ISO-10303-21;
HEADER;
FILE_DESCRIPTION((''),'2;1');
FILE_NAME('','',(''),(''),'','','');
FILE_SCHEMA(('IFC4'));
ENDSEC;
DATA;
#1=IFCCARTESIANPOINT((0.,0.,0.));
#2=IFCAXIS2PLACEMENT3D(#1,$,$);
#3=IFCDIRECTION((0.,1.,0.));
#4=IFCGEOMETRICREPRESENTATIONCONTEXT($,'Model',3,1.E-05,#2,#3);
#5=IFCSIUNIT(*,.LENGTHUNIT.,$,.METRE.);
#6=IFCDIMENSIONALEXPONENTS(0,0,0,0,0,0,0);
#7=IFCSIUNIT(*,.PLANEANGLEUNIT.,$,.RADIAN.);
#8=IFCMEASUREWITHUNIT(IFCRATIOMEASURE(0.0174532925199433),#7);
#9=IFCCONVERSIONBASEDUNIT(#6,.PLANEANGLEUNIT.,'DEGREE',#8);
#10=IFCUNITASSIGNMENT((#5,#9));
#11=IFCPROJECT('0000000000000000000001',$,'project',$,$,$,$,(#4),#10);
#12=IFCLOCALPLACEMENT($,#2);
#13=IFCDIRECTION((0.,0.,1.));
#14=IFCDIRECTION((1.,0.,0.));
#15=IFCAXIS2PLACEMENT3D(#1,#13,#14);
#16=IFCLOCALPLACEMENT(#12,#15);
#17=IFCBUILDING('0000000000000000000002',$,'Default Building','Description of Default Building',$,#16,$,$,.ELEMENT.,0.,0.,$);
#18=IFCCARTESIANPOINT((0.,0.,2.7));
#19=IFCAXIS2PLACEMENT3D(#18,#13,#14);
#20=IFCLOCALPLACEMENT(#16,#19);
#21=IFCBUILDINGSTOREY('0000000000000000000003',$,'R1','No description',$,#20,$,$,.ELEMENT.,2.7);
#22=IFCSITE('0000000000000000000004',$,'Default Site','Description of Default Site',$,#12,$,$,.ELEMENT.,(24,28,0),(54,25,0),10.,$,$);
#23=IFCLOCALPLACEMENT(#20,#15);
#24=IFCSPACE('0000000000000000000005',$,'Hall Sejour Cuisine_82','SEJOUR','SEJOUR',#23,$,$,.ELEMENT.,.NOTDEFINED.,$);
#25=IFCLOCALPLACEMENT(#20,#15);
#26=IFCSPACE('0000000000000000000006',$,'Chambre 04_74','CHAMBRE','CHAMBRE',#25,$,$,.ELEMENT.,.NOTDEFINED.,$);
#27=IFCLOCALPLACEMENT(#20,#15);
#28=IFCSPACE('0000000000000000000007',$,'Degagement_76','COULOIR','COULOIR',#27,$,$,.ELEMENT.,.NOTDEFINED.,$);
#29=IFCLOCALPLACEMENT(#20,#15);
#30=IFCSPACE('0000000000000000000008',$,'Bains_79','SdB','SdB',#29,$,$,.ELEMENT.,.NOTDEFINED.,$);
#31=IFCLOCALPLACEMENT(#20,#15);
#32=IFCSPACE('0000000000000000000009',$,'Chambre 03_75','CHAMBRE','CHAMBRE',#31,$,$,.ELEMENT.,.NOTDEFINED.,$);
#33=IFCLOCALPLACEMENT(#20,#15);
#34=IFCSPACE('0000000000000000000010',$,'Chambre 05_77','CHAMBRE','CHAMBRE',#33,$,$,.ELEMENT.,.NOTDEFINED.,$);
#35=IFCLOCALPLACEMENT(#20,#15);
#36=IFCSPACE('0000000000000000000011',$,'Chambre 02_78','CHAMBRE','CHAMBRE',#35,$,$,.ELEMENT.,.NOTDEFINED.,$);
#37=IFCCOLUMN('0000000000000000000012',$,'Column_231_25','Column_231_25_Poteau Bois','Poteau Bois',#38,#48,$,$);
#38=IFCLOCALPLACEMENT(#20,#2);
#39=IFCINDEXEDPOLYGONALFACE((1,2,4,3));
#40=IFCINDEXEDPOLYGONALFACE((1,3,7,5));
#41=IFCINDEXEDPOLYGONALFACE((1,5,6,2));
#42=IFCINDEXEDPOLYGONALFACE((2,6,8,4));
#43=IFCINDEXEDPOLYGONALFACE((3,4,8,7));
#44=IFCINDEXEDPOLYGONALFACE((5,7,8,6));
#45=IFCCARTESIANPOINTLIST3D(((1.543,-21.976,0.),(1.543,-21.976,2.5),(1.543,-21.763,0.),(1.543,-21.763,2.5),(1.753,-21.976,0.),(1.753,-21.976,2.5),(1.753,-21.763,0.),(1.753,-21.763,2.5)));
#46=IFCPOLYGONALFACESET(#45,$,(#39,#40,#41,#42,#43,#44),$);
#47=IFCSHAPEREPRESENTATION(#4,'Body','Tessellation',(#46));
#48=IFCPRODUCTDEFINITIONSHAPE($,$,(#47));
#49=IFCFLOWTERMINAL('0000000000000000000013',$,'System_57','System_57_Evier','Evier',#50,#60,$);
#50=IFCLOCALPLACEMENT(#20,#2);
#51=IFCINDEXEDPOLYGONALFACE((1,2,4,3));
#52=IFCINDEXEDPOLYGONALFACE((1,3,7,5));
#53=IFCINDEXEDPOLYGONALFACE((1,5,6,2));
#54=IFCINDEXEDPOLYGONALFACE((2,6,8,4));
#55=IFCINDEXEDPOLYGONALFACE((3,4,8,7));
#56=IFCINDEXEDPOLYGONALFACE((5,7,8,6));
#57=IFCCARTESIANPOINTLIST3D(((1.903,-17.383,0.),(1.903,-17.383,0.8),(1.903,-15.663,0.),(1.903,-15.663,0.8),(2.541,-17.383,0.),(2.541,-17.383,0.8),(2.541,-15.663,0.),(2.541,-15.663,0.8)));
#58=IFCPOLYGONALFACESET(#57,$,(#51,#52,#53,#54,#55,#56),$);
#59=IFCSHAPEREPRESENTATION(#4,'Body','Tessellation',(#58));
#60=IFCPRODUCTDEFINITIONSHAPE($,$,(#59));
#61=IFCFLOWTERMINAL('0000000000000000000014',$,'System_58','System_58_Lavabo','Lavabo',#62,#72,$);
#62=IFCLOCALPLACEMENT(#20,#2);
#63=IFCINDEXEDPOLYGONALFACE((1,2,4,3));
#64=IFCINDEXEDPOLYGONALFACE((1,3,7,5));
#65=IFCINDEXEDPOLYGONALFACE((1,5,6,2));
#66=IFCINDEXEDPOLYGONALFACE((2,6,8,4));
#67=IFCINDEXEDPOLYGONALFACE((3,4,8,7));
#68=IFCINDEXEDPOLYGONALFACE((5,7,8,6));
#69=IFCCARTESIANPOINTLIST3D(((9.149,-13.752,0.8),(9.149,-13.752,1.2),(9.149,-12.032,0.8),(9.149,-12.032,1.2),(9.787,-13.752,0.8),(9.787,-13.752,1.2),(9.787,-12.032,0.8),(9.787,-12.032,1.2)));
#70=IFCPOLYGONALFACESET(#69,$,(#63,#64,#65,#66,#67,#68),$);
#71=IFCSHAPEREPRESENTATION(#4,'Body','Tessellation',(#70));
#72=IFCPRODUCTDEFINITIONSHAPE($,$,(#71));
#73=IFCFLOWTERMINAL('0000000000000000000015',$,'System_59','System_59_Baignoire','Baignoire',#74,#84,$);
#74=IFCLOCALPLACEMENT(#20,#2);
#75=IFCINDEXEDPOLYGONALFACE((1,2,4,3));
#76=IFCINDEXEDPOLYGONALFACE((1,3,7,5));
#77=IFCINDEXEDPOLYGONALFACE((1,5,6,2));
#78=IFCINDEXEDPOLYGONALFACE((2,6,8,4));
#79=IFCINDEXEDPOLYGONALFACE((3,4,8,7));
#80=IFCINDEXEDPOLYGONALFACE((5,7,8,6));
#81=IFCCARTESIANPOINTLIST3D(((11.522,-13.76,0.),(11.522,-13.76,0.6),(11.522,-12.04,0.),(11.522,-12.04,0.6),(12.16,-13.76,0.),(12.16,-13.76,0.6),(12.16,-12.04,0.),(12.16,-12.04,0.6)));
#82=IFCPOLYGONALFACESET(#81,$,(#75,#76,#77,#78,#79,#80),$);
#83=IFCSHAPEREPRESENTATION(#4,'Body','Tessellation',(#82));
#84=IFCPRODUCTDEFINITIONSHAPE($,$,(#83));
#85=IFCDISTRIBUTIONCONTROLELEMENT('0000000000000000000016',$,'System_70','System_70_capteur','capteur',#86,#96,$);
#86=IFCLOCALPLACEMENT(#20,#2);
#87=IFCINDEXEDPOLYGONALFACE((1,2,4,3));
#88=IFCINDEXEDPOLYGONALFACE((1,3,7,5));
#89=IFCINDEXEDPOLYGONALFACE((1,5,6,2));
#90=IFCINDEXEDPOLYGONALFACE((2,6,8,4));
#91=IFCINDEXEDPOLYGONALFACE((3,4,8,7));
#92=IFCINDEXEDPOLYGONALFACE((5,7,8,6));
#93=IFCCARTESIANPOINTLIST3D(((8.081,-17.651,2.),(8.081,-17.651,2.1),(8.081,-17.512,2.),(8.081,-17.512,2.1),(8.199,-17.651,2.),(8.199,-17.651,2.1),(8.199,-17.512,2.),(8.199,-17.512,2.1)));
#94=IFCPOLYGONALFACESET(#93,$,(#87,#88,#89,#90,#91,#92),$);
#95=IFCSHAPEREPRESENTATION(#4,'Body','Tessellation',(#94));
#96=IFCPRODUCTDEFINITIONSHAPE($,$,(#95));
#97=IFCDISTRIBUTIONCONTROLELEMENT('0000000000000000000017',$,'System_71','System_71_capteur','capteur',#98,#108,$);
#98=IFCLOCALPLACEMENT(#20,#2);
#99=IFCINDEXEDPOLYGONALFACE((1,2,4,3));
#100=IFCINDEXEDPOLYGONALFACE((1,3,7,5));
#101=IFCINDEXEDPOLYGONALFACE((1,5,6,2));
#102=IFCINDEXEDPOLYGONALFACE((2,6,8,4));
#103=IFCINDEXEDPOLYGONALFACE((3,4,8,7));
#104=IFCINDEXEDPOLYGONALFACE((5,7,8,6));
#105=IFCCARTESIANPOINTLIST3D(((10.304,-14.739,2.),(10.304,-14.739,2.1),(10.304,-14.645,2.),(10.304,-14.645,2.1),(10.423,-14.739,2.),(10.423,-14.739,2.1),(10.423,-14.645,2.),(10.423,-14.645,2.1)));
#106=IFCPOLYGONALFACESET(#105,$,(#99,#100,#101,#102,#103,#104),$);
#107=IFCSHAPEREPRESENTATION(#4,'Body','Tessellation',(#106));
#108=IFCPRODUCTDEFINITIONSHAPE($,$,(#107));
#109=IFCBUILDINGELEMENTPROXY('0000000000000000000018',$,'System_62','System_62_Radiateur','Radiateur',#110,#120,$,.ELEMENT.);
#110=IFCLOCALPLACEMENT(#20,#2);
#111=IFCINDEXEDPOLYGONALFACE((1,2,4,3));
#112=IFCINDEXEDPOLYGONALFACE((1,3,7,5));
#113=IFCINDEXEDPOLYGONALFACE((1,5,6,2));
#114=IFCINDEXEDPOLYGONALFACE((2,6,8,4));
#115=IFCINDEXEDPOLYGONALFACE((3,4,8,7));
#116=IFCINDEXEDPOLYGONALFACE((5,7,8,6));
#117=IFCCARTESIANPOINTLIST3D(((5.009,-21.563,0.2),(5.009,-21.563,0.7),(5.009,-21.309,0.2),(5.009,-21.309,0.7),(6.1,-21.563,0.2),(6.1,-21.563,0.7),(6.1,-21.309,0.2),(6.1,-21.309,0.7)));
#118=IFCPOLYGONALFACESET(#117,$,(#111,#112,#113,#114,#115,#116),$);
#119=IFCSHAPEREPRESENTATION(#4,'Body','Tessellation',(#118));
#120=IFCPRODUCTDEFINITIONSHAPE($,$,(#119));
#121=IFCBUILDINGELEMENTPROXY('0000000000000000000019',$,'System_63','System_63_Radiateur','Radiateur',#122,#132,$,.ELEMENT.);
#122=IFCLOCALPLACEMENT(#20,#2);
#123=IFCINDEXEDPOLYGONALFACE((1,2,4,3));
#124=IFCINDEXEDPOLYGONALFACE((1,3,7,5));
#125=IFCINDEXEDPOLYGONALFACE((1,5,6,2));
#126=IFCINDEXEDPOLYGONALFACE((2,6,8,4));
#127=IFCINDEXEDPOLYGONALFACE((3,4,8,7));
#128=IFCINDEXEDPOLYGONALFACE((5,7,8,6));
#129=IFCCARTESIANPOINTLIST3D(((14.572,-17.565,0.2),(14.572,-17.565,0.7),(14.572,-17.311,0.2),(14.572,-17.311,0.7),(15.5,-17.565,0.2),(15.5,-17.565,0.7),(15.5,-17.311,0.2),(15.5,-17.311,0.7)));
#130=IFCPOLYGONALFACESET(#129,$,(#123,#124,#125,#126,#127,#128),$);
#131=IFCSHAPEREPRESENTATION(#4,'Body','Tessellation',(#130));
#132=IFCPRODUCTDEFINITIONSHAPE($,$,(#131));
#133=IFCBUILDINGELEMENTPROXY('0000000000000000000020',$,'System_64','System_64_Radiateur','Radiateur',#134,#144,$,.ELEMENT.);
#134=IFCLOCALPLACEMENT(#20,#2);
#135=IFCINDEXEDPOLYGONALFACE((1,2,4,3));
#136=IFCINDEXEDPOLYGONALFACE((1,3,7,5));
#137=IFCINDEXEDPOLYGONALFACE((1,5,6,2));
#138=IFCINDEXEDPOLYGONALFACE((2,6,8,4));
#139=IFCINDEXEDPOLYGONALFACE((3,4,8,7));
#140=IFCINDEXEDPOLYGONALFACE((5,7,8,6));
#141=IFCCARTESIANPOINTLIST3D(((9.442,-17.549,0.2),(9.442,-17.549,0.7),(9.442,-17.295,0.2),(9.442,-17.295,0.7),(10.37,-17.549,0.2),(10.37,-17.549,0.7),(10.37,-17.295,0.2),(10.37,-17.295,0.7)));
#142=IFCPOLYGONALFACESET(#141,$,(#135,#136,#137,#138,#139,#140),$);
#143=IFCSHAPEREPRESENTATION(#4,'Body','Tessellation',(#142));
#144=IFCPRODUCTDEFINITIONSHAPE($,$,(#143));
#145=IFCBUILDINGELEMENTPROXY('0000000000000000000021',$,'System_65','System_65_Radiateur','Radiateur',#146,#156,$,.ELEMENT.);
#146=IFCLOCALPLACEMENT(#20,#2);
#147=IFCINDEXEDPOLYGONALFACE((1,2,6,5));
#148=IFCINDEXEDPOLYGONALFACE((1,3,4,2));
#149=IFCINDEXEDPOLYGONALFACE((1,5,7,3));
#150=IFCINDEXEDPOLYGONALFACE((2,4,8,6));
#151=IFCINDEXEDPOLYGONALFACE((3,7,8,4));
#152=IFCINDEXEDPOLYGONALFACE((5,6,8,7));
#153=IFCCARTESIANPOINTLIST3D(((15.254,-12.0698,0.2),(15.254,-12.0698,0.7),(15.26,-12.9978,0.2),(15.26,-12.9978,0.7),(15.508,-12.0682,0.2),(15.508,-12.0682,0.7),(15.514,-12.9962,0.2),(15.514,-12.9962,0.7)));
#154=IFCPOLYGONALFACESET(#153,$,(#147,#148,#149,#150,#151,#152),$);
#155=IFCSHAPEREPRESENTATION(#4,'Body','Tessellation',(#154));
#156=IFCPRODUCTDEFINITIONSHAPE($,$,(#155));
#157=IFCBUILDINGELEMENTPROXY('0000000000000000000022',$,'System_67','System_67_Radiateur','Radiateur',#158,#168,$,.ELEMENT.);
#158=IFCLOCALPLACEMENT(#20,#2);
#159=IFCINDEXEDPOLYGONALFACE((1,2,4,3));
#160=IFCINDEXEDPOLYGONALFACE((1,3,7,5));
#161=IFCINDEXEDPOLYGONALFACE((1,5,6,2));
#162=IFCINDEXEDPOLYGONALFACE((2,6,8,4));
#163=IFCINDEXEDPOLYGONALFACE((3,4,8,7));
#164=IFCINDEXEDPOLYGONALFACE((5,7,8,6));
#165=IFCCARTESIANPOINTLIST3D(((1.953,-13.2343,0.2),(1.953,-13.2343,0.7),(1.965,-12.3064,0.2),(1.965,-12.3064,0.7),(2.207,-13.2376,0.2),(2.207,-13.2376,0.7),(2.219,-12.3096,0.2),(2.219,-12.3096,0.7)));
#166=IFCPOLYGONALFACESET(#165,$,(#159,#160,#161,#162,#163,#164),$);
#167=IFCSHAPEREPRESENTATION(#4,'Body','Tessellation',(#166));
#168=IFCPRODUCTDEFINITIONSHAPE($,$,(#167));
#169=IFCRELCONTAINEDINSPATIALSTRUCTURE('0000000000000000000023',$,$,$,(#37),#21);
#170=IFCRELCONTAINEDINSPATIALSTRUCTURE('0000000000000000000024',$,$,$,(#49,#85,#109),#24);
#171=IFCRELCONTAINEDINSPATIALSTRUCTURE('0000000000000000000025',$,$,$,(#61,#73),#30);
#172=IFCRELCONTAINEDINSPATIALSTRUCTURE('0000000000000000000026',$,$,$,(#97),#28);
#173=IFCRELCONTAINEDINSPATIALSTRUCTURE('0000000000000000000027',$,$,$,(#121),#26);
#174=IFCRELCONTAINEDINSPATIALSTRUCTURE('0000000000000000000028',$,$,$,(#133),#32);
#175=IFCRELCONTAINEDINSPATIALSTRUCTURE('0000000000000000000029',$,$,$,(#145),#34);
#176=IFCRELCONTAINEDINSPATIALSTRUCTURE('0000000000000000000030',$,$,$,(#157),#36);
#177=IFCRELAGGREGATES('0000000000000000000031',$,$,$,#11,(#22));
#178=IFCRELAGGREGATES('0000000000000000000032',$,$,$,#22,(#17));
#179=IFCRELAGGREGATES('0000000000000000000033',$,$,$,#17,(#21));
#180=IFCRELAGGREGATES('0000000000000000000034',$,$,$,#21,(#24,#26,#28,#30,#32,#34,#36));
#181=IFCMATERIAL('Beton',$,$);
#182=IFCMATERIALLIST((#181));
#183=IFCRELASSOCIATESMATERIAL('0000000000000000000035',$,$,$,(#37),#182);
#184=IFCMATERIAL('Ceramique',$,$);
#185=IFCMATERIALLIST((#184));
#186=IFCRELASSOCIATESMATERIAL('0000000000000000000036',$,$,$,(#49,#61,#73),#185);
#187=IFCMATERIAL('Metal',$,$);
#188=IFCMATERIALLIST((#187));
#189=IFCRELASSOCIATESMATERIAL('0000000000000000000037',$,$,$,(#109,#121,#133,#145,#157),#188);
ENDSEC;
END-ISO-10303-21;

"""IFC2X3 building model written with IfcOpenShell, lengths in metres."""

from ifc_helpers import new_model, entity, si_unit, converted_unit, direction, frame, origin, origin_with_axes, place, context, project, spatial, polyline, outline, extrude, material, material_list, element, save


model = new_model("IFC2X3")

# Units and contexts
model_context = context("Model", 3, precision=1e-05, world=origin(), true_north=direction((0.0, 1.0, 0.0)))
ifc_project = project(units=[si_unit("LENGTHUNIT", "METRE"), converted_unit("PLANEANGLEUNIT", "DEGREE", entity("IfcRatioMeasure", 0.0174532925199433), si_unit("PLANEANGLEUNIT", "RADIAN"), dimensions=[0, 0, 0, 0, 0, 0, 0])], contexts=[model_context])

# Site, building, storey
site_placement = place(None, origin())
site = spatial("IfcSite", under=ifc_project, at=site_placement, Name="Default Site", Description="Description of Default Site", CompositionType="ELEMENT", RefLatitude=(24, 28, 0), RefLongitude=(54, 25, 0), RefElevation=10.0)
building_placement = place(site_placement, origin_with_axes())
building = spatial("IfcBuilding", under=site, at=building_placement, Name="Default Building", Description="Description of Default Building", CompositionType="ELEMENT", ElevationOfRefHeight=0.0, ElevationOfTerrain=0.0)
storey_placement = place(building_placement, frame((0.0, 0.0, 2.7), z_axis=(0.0, 0.0, 1.0), x_axis=(1.0, 0.0, 0.0)))
storey = spatial("IfcBuildingStorey", under=building, at=storey_placement, Name="R1", Description="No description", CompositionType="ELEMENT", Elevation=2.7)

# Column
ifc_material_1 = material(Name="Beton")
ifc_material_list_1 = material_list([ifc_material_1])
column_placement = place(storey_placement, frame((1.648, -21.763, 0.0), z_axis=(0.0, 0.0, 1.0), x_axis=(0.0, -0.213, 0.0)))
element("IfcColumn", 1, at=column_placement, inside=storey, material=ifc_material_list_1, Name="Column_231_25", Description="Column_231_25_Poteau Bois", ObjectType="Poteau Bois", context=model_context, shape_type="SweptSolid", body=[
    extrude(outline(polyline([(0.0, -0.105), (0.213, -0.105), (0.213, 0.105), (0.0, 0.105), (0.0, -0.105)])), origin(), (0.0, 0.0, 1.0), 2.5),
])

# Shared definitions
space_1_placement = place(storey_placement, origin_with_axes())
space_1 = spatial("IfcSpace", under=storey, at=space_1_placement, Name="Hall Sejour Cuisine_82", Description="SEJOUR", ObjectType="SEJOUR", CompositionType="ELEMENT", InteriorOrExteriorSpace="NOTDEFINED")

# Shared definitions
space_2_placement = place(storey_placement, origin_with_axes())
space_2 = spatial("IfcSpace", under=storey, at=space_2_placement, Name="Chambre 04_74", Description="CHAMBRE", ObjectType="CHAMBRE", CompositionType="ELEMENT", InteriorOrExteriorSpace="NOTDEFINED")

# Shared definitions
space_3_placement = place(storey_placement, origin_with_axes())
space_3 = spatial("IfcSpace", under=storey, at=space_3_placement, Name="Degagement_76", Description="COULOIR", ObjectType="COULOIR", CompositionType="ELEMENT", InteriorOrExteriorSpace="NOTDEFINED")

# Shared definitions
ifc_material_2 = material(Name="Metal")
ifc_material_list_2 = material_list([ifc_material_2])

# Flow terminal
ifc_material_3 = material(Name="Ceramique")
ifc_material_list_3 = material_list([ifc_material_3])
flow_terminal_1_placement = place(storey_placement, frame((2.222, -15.663, 0.0), z_axis=(0.0, 0.0, 1.0), x_axis=(0.0, -1.72, 0.0)))
element("IfcFlowTerminal", 2, at=flow_terminal_1_placement, inside=space_1, material=ifc_material_list_3, Name="System_57", Description="System_57_Evier", ObjectType="Evier", context=model_context, shape_type="SweptSolid", body=[
    extrude(outline(polyline([(0.0, -0.319), (1.72, -0.319), (1.72, 0.319), (0.0, 0.319), (0.0, -0.319)])), origin(), (0.0, 0.0, 1.0), 0.8),
])

# Shared definitions
space_4_placement = place(storey_placement, origin_with_axes())
space_4 = spatial("IfcSpace", under=storey, at=space_4_placement, Name="Bains_79", Description="SdB", ObjectType="SdB", CompositionType="ELEMENT", InteriorOrExteriorSpace="NOTDEFINED")

# Flow terminals
flow_terminal_2_placement = place(storey_placement, frame((9.468, -12.032, 0.8), z_axis=(0.0, 0.0, 1.0), x_axis=(0.0, -1.72, 0.0)))
element("IfcFlowTerminal", 3, at=flow_terminal_2_placement, inside=space_4, material=ifc_material_list_3, Name="System_58", Description="System_58_Lavabo", ObjectType="Lavabo", context=model_context, shape_type="SweptSolid", body=[
    extrude(outline(polyline([(0.0, -0.319), (1.72, -0.319), (1.72, 0.319), (0.0, 0.319), (0.0, -0.319)])), origin(), (0.0, 0.0, 1.0), 0.4),
])
flow_terminal_3_placement = place(storey_placement, frame((11.841, -12.04, 0.0), z_axis=(0.0, 0.0, 1.0), x_axis=(0.0, -1.72, 0.0)))
element("IfcFlowTerminal", 4, at=flow_terminal_3_placement, inside=space_4, material=ifc_material_list_3, Name="System_59", Description="System_59_Baignoire", ObjectType="Baignoire", context=model_context, shape_type="SweptSolid", body=[
    extrude(outline(polyline([(0.0, -0.319), (1.72, -0.319), (1.72, 0.319), (0.0, 0.319), (0.0, -0.319)])), origin(), (0.0, 0.0, 1.0), 0.6),
])

# Distribution control elements
distribution_control_element_1_placement = place(storey_placement, frame((8.14, -17.512, 2.0), z_axis=(0.0, 0.0, 1.0), x_axis=(0.0, -0.139, 0.0)))
element("IfcDistributionControlElement", 5, at=distribution_control_element_1_placement, inside=space_1, Name="System_70", Description="System_70_capteur", ObjectType="capteur", context=model_context, shape_type="SweptSolid", body=[
    extrude(outline(polyline([(0.0, -0.059), (0.139, -0.059), (0.139, 0.059), (0.0, 0.059), (0.0, -0.059)])), origin(), (0.0, 0.0, 1.0), 0.1),
])
distribution_control_element_2_placement = place(storey_placement, frame((10.304, -14.692, 2.0), z_axis=(0.0, 0.0, 1.0), x_axis=(0.119, 0.0, 0.0)))
element("IfcDistributionControlElement", 6, at=distribution_control_element_2_placement, inside=space_3, Name="System_71", Description="System_71_capteur", ObjectType="capteur", context=model_context, shape_type="SweptSolid", body=[
    extrude(outline(polyline([(0.0, -0.047), (0.119, -0.047), (0.119, 0.047), (0.0, 0.047), (0.0, -0.047)])), origin(), (0.0, 0.0, 1.0), 0.1),
])

# Building element proxies
proxy_1_placement = place(storey_placement, frame((5.009, -21.436, 0.2), z_axis=(0.0, 0.0, 1.0), x_axis=(1.091, 0.0, 0.0)))
element("IfcBuildingElementProxy", 7, at=proxy_1_placement, inside=space_1, material=ifc_material_list_2, Name="System_62", Description="System_62_Radiateur", ObjectType="Radiateur", CompositionType="ELEMENT", context=model_context, shape_type="SweptSolid", body=[
    extrude(outline(polyline([(0.0, -0.127), (1.091, -0.127), (1.091, 0.127), (0.0, 0.127), (0.0, -0.127)])), origin(), (0.0, 0.0, 1.0), 0.5),
])
proxy_2_placement = place(storey_placement, frame((14.572, -17.438, 0.2), z_axis=(0.0, 0.0, 1.0), x_axis=(0.928, 0.0, 0.0)))
element("IfcBuildingElementProxy", 8, at=proxy_2_placement, inside=space_2, material=ifc_material_list_2, Name="System_63", Description="System_63_Radiateur", ObjectType="Radiateur", CompositionType="ELEMENT", context=model_context, shape_type="SweptSolid", body=[
    extrude(outline(polyline([(0.0, -0.127), (0.928, -0.127), (0.928, 0.127), (0.0, 0.127), (0.0, -0.127)])), origin(), (0.0, 0.0, 1.0), 0.5),
])

# Shared definitions
space_5_placement = place(storey_placement, origin_with_axes())
space_5 = spatial("IfcSpace", under=storey, at=space_5_placement, Name="Chambre 03_75", Description="CHAMBRE", ObjectType="CHAMBRE", CompositionType="ELEMENT", InteriorOrExteriorSpace="NOTDEFINED")

# Building element proxy
proxy_3_placement = place(storey_placement, frame((9.442, -17.422, 0.2), z_axis=(0.0, 0.0, 1.0), x_axis=(0.928, 0.0, 0.0)))
element("IfcBuildingElementProxy", 9, at=proxy_3_placement, inside=space_5, material=ifc_material_list_2, Name="System_64", Description="System_64_Radiateur", ObjectType="Radiateur", CompositionType="ELEMENT", context=model_context, shape_type="SweptSolid", body=[
    extrude(outline(polyline([(0.0, -0.127), (0.928, -0.127), (0.928, 0.127), (0.0, 0.127), (0.0, -0.127)])), origin(), (0.0, 0.0, 1.0), 0.5),
])

# Shared definitions
space_6_placement = place(storey_placement, origin_with_axes())
space_6 = spatial("IfcSpace", under=storey, at=space_6_placement, Name="Chambre 05_77", Description="CHAMBRE", ObjectType="CHAMBRE", CompositionType="ELEMENT", InteriorOrExteriorSpace="NOTDEFINED")

# Building element proxy
proxy_4_placement = place(storey_placement, frame((15.381, -12.069, 0.2), z_axis=(0.0, 0.0, 1.0), x_axis=(0.006, -0.928, 0.0)))
element("IfcBuildingElementProxy", 10, at=proxy_4_placement, inside=space_6, material=ifc_material_list_2, Name="System_65", Description="System_65_Radiateur", ObjectType="Radiateur", CompositionType="ELEMENT", context=model_context, shape_type="SweptSolid", body=[
    extrude(outline(polyline([(0.0, -0.127), (0.928, -0.127), (0.928, 0.127), (0.0, 0.127), (0.0, -0.127)])), origin(), (0.0, 0.0, 1.0), 0.5),
])

# Shared definitions
space_7_placement = place(storey_placement, origin_with_axes())
space_7 = spatial("IfcSpace", under=storey, at=space_7_placement, Name="Chambre 02_78", Description="CHAMBRE", ObjectType="CHAMBRE", CompositionType="ELEMENT", InteriorOrExteriorSpace="NOTDEFINED")

# Building element proxy
proxy_5_placement = place(storey_placement, frame((2.092, -12.308, 0.2), z_axis=(0.0, 0.0, 1.0), x_axis=(-0.012, -0.928, 0.0)))
element("IfcBuildingElementProxy", 11, at=proxy_5_placement, inside=space_7, material=ifc_material_list_2, Name="System_67", Description="System_67_Radiateur", ObjectType="Radiateur", CompositionType="ELEMENT", context=model_context, shape_type="SweptSolid", body=[
    extrude(outline(polyline([(0.0, -0.127), (0.928, -0.127), (0.928, 0.127), (0.0, 0.127), (0.0, -0.127)])), origin(), (0.0, 0.0, 1.0), 0.5),
])

save(model, "model.ifc")
